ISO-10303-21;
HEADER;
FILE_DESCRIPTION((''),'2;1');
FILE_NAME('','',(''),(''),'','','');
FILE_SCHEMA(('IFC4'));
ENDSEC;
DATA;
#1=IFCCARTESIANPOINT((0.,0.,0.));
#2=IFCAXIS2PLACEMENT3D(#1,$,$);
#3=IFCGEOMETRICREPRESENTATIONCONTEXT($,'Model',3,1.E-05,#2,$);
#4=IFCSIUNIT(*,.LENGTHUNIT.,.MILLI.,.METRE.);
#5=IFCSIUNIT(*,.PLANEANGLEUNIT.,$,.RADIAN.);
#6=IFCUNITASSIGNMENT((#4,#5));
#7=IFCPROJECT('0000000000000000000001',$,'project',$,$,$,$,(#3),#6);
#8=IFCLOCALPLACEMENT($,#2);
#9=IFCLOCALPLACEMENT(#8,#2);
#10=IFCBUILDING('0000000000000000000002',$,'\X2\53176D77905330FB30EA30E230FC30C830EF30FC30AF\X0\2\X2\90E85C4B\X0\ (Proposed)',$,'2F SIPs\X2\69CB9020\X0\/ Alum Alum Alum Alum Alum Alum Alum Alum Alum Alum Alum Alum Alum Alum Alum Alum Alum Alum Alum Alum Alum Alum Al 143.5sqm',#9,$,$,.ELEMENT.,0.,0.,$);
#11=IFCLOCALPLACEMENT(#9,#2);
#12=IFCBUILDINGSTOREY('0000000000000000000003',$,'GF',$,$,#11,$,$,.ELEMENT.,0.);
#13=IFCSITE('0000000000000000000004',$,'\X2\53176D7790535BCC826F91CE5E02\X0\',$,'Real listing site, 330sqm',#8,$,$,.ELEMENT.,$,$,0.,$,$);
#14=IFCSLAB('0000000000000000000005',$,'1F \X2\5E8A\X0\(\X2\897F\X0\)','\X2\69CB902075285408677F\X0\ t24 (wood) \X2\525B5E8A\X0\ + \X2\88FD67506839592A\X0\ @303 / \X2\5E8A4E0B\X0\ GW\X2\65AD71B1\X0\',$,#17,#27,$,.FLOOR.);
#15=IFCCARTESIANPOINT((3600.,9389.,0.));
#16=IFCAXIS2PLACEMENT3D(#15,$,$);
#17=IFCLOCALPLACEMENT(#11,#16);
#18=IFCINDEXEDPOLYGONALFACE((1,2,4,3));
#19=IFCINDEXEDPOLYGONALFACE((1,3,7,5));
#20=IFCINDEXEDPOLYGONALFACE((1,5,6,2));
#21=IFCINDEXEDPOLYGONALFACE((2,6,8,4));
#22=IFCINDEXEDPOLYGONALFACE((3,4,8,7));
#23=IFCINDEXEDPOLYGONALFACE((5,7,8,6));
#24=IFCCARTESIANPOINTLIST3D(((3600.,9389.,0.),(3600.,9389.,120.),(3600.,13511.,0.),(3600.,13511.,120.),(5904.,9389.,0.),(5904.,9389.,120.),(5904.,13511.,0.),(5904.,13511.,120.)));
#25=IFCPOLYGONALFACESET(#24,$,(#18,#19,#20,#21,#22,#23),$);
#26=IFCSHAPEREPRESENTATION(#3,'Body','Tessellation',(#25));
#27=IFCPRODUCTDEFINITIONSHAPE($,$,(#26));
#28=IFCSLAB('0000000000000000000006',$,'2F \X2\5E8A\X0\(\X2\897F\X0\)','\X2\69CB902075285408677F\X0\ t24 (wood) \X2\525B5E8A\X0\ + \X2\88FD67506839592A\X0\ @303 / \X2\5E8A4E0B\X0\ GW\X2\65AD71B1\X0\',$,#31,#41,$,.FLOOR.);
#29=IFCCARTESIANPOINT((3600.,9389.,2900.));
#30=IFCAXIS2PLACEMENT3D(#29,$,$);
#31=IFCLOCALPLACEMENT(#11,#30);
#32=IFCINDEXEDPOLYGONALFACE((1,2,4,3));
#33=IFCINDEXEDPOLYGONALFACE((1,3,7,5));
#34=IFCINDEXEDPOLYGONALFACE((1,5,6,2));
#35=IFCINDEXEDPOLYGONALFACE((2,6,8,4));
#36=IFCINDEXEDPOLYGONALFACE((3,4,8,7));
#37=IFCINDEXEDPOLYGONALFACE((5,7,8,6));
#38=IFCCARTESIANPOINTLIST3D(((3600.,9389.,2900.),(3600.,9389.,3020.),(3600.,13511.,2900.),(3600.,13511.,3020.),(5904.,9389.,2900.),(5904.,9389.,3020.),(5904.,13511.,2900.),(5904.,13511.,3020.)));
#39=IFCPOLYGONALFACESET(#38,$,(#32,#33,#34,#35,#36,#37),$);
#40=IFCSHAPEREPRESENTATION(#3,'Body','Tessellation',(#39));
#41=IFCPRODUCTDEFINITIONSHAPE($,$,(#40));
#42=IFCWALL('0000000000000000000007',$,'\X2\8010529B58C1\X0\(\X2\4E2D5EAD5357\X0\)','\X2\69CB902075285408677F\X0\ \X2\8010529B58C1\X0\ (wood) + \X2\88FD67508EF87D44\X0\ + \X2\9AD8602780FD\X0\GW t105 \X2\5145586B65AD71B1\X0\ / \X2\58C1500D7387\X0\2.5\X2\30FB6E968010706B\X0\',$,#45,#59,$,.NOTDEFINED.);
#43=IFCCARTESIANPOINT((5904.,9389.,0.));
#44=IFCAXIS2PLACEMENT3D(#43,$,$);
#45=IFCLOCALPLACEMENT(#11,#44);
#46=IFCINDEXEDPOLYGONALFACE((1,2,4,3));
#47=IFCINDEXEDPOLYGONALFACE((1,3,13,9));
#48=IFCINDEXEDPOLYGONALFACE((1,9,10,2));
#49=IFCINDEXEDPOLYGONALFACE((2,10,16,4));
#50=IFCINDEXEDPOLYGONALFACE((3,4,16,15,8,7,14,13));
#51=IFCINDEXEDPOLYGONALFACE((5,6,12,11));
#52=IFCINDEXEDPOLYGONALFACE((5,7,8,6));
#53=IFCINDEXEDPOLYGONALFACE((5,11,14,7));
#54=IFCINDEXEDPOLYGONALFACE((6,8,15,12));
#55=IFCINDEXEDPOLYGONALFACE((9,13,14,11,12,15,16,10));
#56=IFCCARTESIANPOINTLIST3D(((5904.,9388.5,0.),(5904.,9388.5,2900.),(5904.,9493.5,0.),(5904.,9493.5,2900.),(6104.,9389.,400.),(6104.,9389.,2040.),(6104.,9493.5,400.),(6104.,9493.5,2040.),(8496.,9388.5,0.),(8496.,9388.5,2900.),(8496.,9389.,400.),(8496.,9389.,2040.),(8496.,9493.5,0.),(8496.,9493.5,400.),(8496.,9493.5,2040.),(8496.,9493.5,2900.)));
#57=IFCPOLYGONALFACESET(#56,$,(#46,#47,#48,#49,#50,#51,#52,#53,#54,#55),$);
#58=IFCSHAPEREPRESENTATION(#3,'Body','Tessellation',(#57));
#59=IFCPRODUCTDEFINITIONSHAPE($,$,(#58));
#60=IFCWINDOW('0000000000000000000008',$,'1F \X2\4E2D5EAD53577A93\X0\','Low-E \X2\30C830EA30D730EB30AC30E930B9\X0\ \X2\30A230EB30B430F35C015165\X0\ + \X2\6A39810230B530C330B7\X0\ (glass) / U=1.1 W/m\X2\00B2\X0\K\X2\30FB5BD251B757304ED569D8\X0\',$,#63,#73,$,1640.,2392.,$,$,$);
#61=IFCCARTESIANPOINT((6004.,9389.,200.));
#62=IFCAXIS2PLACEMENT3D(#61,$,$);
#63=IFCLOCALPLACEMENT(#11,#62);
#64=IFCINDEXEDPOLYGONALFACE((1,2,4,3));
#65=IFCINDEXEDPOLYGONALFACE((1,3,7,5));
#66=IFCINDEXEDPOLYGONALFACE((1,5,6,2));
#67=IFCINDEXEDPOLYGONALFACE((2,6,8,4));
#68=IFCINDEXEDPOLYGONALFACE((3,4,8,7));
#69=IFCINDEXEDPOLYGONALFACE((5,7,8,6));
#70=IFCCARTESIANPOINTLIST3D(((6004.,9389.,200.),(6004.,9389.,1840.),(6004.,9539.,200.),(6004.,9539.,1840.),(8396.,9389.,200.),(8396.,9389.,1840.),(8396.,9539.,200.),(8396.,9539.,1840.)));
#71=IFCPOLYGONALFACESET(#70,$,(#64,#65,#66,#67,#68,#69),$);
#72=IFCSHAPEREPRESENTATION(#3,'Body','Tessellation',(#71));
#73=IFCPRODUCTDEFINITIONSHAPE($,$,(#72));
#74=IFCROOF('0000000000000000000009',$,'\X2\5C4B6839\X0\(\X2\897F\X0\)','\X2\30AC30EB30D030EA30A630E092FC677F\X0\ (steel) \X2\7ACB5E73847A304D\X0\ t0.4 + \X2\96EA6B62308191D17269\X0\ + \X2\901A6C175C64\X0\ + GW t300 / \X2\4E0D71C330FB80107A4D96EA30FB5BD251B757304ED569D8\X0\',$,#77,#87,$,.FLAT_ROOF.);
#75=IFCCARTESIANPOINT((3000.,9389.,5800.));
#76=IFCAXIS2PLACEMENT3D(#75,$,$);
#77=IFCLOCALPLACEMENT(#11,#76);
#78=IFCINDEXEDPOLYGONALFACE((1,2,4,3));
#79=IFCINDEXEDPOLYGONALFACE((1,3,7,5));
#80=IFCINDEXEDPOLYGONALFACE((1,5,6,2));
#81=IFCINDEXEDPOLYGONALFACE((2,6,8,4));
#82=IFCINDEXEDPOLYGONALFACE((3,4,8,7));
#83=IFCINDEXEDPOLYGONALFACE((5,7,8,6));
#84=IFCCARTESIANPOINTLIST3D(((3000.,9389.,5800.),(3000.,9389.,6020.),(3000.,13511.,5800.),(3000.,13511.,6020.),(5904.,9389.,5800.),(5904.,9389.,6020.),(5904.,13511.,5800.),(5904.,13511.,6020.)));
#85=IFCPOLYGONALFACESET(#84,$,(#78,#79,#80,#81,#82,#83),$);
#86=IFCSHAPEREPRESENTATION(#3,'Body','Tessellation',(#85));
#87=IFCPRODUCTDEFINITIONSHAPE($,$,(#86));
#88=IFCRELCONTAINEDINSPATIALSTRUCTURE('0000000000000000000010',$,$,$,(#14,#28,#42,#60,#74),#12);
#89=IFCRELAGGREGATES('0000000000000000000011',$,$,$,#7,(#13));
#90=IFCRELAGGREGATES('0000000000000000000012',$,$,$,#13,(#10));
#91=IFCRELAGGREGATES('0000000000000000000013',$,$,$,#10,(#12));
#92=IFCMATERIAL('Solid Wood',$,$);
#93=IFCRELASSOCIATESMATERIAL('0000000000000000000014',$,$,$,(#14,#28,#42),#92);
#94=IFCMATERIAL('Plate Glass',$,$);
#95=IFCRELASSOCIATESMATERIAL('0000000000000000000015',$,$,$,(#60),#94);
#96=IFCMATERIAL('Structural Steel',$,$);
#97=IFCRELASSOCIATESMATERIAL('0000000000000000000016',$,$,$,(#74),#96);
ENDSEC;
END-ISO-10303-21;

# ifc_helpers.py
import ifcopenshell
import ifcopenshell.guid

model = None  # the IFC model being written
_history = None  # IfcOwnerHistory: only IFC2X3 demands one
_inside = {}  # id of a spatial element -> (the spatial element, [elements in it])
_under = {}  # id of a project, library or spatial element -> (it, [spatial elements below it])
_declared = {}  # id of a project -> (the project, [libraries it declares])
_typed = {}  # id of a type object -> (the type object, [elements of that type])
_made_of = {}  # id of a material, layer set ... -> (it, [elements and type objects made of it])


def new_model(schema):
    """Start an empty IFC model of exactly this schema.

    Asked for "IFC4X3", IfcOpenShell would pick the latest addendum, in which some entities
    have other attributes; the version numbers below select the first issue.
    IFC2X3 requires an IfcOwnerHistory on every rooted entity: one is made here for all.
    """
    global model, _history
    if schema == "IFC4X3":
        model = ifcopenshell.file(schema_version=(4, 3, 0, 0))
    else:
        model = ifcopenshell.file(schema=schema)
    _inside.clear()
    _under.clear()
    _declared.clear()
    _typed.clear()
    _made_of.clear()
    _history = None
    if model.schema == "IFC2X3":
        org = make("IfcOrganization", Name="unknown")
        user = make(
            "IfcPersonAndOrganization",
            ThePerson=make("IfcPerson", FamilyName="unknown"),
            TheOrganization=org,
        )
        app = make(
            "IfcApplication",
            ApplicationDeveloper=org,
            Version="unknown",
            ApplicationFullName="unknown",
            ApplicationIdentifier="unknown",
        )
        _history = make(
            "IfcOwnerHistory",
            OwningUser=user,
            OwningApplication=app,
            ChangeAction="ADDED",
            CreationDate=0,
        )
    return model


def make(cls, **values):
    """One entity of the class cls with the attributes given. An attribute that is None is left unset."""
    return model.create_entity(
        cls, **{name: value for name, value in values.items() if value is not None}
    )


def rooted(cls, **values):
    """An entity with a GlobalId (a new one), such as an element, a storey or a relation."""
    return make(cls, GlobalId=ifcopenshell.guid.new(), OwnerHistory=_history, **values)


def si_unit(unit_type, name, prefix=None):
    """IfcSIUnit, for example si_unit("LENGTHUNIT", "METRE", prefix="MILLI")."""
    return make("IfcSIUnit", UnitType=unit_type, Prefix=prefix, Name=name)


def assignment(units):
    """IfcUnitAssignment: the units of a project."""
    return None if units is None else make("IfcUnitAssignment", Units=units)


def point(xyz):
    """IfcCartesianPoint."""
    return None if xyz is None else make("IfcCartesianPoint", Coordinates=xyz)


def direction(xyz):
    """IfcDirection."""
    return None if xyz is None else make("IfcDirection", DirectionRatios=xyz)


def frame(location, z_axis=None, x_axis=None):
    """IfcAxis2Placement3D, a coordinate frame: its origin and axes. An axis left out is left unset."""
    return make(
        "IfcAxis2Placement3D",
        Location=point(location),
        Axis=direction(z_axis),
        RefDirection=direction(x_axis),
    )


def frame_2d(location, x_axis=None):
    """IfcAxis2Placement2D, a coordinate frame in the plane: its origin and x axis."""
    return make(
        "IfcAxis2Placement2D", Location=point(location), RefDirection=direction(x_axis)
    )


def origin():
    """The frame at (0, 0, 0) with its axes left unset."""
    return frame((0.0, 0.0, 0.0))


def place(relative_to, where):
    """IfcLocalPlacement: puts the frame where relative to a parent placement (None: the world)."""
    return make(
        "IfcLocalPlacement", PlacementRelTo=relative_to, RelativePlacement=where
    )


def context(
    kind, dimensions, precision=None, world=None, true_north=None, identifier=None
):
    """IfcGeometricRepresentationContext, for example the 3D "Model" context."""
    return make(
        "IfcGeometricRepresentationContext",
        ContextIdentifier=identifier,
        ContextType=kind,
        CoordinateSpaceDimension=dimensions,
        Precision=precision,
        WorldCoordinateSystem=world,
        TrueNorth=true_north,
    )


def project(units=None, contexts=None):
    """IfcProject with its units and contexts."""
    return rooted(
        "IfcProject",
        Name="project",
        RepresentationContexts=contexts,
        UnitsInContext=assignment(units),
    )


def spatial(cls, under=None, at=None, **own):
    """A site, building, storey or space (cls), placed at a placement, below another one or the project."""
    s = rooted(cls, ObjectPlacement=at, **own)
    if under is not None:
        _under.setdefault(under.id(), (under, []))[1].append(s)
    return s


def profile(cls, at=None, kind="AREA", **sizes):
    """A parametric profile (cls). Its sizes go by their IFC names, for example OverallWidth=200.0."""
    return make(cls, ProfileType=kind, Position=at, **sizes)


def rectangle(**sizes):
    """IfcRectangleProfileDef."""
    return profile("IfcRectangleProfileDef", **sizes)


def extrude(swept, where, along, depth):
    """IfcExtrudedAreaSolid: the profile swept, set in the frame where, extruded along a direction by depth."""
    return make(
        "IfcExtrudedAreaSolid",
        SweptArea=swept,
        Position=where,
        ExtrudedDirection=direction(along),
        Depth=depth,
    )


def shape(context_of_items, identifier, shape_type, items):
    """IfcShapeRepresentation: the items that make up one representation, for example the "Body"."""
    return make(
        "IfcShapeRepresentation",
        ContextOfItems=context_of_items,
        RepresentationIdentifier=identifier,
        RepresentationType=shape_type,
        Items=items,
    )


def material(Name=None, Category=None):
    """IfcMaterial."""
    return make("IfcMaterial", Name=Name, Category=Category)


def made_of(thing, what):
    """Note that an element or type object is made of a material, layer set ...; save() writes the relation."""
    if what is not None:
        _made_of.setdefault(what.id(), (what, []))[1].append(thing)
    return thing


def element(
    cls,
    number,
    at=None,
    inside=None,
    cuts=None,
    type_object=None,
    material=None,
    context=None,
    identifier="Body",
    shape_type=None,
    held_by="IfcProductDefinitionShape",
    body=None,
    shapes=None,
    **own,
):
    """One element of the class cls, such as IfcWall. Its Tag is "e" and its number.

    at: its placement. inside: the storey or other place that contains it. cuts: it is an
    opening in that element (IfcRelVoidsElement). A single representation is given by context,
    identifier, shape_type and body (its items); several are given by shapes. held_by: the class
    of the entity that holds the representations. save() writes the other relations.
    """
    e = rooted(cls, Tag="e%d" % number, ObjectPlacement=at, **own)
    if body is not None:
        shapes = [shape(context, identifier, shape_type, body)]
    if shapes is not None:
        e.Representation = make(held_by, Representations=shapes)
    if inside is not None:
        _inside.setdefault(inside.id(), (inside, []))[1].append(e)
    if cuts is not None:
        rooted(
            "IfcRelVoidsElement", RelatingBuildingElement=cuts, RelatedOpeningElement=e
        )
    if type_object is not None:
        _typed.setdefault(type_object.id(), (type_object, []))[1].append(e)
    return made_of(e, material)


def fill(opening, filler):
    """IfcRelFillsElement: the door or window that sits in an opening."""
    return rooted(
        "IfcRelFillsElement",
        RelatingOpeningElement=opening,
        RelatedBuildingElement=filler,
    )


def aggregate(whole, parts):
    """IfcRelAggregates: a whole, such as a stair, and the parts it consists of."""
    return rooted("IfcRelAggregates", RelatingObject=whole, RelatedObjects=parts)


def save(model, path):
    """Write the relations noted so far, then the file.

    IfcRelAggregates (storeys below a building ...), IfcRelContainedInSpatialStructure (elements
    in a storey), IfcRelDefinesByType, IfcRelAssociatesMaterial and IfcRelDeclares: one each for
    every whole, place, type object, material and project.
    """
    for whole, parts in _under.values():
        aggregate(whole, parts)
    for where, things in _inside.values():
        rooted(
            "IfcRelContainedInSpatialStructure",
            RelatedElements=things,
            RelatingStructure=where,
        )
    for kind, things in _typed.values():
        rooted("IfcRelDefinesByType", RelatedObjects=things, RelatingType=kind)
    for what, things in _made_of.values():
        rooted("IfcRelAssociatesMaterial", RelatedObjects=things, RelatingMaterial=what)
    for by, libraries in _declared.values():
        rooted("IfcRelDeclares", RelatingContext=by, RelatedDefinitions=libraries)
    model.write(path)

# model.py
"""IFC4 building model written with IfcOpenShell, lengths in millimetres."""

from ifc_helpers import new_model, si_unit, frame, frame_2d, origin, place, context, project, spatial, rectangle, extrude, material, element, fill, save


model = new_model("IFC4")

# Units and contexts
model_context = context("Model", 3, precision=1e-05, world=origin())
ifc_project = project(units=[si_unit("LENGTHUNIT", "METRE", prefix="MILLI"), si_unit("PLANEANGLEUNIT", "RADIAN")], contexts=[model_context])

# Site, building, storey
site_placement = place(None, origin())
site = spatial("IfcSite", under=ifc_project, at=site_placement, Name="北海道富良野市", ObjectType="Real listing site, 330sqm", CompositionType="ELEMENT", RefElevation=0.0)
building_placement = place(site_placement, origin())
building = spatial("IfcBuilding", under=site, at=building_placement, Name="北海道・リモートワーク2部屋 (Proposed)", ObjectType="2F SIPs構造/ Alum Alum Alum Alum Alum Alum Alum Alum Alum Alum Alum Alum Alum Alum Alum Alum Alum Alum Alum Alum Alum Alum Al 143.5sqm", CompositionType="ELEMENT", ElevationOfRefHeight=0.0, ElevationOfTerrain=0.0)
storey_placement = place(building_placement, origin())
storey = spatial("IfcBuildingStorey", under=building, at=storey_placement, Name="GF", CompositionType="ELEMENT", Elevation=0.0)

# Shared definitions
ifc_material_1 = material(Name="Solid Wood")

# Slabs
slab_1_placement = place(storey_placement, frame((3600.0, 9389.0, 0.0)))
element("IfcSlab", 1, at=slab_1_placement, inside=storey, material=ifc_material_1, Name="1F 床(西)", Description="構造用合板 t24 (wood) 剛床 + 製材根太 @303 / 床下 GW断熱", PredefinedType="FLOOR", context=model_context, shape_type="SweptSolid", body=[
    extrude(rectangle(XDim=2304.0, YDim=4122.0, at=frame_2d((1152.0, 2061.0))), frame((3600.0, 9389.0, 0.0)), (0.0, 0.0, 1.0), 120.0),
])
slab_2_placement = place(storey_placement, frame((3600.0, 9389.0, 2900.0)))
element("IfcSlab", 2, at=slab_2_placement, inside=storey, material=ifc_material_1, Name="2F 床(西)", Description="構造用合板 t24 (wood) 剛床 + 製材根太 @303 / 床下 GW断熱", PredefinedType="FLOOR", context=model_context, shape_type="SweptSolid", body=[
    extrude(rectangle(XDim=2304.0, YDim=4122.0, at=frame_2d((1152.0, 2061.0))), frame((3600.0, 9389.0, 2900.0)), (0.0, 0.0, 1.0), 120.0),
])

# Wall, opening, window
wall_1_placement = place(storey_placement, frame((5904.0, 9389.0, 0.0)))
wall_1 = element("IfcWall", 3, at=wall_1_placement, inside=storey, material=ifc_material_1, Name="耐力壁(中庭南)", Description="構造用合板 耐力壁 (wood) + 製材軸組 + 高性能GW t105 充填断熱 / 壁倍率2.5・準耐火", PredefinedType="NOTDEFINED", context=model_context, shape_type="SweptSolid", body=[
    extrude(rectangle(XDim=2592.0, YDim=105.0, at=frame_2d((1296.0, 52.0))), frame((5904.0, 9389.0, 0.0)), (0.0, 0.0, 1.0), 2900.0),
])
opening_placement = place(storey_placement, frame((6004.0, 9389.0, 200.0)))
opening = element("IfcOpeningElement", 4, at=opening_placement, cuts=wall_1, PredefinedType="NOTDEFINED", context=model_context, shape_type="SweptSolid", body=[
    extrude(rectangle(XDim=2392.0, YDim=150.0, at=frame_2d((1196.0, 75.0))), frame((6004.0, 9389.0, 200.0)), (0.0, 0.0, 1.0), 1640.0),
])
ifc_material_2 = material(Name="Plate Glass")
window_placement = place(storey_placement, frame((6004.0, 9389.0, 200.0)))
window = element("IfcWindow", 5, at=window_placement, inside=storey, material=ifc_material_2, Name="1F 中庭南窓", Description="Low-E トリプルガラス アルゴン封入 + 樹脂サッシ (glass) / U=1.1 W/m²K・寒冷地仕様", OverallHeight=1640.0, OverallWidth=2392.0, context=model_context, shape_type="SweptSolid", body=[
    extrude(rectangle(XDim=2392.0, YDim=150.0, at=frame_2d((1196.0, 75.0))), frame((6004.0, 9389.0, 200.0)), (0.0, 0.0, 1.0), 1640.0),
])
fill(opening, window)

# Roof
ifc_material_3 = material(Name="Structural Steel")
for number, where, name in (
    (6, (3000.0, 9389.0, 5800.0), "屋根(西)"),
):
    element("IfcRoof", number, at=place(storey_placement, frame(where)), inside=storey, material=ifc_material_3, Name=name, Description="ガルバリウム鋼板 (steel) 立平葺き t0.4 + 雪止め金物 + 通気層 + GW t300 / 不燃・耐積雪・寒冷地仕様", PredefinedType="FLAT_ROOF", context=model_context, shape_type="SweptSolid", body=[
        extrude(rectangle(XDim=2904.0, YDim=4122.0, at=frame_2d((1452.0, 2061.0))), frame((3000.0, 9389.0, 5800.0)), (0.0, 0.0, 1.0), 220.0),
    ])

save(model, "model.ifc")
